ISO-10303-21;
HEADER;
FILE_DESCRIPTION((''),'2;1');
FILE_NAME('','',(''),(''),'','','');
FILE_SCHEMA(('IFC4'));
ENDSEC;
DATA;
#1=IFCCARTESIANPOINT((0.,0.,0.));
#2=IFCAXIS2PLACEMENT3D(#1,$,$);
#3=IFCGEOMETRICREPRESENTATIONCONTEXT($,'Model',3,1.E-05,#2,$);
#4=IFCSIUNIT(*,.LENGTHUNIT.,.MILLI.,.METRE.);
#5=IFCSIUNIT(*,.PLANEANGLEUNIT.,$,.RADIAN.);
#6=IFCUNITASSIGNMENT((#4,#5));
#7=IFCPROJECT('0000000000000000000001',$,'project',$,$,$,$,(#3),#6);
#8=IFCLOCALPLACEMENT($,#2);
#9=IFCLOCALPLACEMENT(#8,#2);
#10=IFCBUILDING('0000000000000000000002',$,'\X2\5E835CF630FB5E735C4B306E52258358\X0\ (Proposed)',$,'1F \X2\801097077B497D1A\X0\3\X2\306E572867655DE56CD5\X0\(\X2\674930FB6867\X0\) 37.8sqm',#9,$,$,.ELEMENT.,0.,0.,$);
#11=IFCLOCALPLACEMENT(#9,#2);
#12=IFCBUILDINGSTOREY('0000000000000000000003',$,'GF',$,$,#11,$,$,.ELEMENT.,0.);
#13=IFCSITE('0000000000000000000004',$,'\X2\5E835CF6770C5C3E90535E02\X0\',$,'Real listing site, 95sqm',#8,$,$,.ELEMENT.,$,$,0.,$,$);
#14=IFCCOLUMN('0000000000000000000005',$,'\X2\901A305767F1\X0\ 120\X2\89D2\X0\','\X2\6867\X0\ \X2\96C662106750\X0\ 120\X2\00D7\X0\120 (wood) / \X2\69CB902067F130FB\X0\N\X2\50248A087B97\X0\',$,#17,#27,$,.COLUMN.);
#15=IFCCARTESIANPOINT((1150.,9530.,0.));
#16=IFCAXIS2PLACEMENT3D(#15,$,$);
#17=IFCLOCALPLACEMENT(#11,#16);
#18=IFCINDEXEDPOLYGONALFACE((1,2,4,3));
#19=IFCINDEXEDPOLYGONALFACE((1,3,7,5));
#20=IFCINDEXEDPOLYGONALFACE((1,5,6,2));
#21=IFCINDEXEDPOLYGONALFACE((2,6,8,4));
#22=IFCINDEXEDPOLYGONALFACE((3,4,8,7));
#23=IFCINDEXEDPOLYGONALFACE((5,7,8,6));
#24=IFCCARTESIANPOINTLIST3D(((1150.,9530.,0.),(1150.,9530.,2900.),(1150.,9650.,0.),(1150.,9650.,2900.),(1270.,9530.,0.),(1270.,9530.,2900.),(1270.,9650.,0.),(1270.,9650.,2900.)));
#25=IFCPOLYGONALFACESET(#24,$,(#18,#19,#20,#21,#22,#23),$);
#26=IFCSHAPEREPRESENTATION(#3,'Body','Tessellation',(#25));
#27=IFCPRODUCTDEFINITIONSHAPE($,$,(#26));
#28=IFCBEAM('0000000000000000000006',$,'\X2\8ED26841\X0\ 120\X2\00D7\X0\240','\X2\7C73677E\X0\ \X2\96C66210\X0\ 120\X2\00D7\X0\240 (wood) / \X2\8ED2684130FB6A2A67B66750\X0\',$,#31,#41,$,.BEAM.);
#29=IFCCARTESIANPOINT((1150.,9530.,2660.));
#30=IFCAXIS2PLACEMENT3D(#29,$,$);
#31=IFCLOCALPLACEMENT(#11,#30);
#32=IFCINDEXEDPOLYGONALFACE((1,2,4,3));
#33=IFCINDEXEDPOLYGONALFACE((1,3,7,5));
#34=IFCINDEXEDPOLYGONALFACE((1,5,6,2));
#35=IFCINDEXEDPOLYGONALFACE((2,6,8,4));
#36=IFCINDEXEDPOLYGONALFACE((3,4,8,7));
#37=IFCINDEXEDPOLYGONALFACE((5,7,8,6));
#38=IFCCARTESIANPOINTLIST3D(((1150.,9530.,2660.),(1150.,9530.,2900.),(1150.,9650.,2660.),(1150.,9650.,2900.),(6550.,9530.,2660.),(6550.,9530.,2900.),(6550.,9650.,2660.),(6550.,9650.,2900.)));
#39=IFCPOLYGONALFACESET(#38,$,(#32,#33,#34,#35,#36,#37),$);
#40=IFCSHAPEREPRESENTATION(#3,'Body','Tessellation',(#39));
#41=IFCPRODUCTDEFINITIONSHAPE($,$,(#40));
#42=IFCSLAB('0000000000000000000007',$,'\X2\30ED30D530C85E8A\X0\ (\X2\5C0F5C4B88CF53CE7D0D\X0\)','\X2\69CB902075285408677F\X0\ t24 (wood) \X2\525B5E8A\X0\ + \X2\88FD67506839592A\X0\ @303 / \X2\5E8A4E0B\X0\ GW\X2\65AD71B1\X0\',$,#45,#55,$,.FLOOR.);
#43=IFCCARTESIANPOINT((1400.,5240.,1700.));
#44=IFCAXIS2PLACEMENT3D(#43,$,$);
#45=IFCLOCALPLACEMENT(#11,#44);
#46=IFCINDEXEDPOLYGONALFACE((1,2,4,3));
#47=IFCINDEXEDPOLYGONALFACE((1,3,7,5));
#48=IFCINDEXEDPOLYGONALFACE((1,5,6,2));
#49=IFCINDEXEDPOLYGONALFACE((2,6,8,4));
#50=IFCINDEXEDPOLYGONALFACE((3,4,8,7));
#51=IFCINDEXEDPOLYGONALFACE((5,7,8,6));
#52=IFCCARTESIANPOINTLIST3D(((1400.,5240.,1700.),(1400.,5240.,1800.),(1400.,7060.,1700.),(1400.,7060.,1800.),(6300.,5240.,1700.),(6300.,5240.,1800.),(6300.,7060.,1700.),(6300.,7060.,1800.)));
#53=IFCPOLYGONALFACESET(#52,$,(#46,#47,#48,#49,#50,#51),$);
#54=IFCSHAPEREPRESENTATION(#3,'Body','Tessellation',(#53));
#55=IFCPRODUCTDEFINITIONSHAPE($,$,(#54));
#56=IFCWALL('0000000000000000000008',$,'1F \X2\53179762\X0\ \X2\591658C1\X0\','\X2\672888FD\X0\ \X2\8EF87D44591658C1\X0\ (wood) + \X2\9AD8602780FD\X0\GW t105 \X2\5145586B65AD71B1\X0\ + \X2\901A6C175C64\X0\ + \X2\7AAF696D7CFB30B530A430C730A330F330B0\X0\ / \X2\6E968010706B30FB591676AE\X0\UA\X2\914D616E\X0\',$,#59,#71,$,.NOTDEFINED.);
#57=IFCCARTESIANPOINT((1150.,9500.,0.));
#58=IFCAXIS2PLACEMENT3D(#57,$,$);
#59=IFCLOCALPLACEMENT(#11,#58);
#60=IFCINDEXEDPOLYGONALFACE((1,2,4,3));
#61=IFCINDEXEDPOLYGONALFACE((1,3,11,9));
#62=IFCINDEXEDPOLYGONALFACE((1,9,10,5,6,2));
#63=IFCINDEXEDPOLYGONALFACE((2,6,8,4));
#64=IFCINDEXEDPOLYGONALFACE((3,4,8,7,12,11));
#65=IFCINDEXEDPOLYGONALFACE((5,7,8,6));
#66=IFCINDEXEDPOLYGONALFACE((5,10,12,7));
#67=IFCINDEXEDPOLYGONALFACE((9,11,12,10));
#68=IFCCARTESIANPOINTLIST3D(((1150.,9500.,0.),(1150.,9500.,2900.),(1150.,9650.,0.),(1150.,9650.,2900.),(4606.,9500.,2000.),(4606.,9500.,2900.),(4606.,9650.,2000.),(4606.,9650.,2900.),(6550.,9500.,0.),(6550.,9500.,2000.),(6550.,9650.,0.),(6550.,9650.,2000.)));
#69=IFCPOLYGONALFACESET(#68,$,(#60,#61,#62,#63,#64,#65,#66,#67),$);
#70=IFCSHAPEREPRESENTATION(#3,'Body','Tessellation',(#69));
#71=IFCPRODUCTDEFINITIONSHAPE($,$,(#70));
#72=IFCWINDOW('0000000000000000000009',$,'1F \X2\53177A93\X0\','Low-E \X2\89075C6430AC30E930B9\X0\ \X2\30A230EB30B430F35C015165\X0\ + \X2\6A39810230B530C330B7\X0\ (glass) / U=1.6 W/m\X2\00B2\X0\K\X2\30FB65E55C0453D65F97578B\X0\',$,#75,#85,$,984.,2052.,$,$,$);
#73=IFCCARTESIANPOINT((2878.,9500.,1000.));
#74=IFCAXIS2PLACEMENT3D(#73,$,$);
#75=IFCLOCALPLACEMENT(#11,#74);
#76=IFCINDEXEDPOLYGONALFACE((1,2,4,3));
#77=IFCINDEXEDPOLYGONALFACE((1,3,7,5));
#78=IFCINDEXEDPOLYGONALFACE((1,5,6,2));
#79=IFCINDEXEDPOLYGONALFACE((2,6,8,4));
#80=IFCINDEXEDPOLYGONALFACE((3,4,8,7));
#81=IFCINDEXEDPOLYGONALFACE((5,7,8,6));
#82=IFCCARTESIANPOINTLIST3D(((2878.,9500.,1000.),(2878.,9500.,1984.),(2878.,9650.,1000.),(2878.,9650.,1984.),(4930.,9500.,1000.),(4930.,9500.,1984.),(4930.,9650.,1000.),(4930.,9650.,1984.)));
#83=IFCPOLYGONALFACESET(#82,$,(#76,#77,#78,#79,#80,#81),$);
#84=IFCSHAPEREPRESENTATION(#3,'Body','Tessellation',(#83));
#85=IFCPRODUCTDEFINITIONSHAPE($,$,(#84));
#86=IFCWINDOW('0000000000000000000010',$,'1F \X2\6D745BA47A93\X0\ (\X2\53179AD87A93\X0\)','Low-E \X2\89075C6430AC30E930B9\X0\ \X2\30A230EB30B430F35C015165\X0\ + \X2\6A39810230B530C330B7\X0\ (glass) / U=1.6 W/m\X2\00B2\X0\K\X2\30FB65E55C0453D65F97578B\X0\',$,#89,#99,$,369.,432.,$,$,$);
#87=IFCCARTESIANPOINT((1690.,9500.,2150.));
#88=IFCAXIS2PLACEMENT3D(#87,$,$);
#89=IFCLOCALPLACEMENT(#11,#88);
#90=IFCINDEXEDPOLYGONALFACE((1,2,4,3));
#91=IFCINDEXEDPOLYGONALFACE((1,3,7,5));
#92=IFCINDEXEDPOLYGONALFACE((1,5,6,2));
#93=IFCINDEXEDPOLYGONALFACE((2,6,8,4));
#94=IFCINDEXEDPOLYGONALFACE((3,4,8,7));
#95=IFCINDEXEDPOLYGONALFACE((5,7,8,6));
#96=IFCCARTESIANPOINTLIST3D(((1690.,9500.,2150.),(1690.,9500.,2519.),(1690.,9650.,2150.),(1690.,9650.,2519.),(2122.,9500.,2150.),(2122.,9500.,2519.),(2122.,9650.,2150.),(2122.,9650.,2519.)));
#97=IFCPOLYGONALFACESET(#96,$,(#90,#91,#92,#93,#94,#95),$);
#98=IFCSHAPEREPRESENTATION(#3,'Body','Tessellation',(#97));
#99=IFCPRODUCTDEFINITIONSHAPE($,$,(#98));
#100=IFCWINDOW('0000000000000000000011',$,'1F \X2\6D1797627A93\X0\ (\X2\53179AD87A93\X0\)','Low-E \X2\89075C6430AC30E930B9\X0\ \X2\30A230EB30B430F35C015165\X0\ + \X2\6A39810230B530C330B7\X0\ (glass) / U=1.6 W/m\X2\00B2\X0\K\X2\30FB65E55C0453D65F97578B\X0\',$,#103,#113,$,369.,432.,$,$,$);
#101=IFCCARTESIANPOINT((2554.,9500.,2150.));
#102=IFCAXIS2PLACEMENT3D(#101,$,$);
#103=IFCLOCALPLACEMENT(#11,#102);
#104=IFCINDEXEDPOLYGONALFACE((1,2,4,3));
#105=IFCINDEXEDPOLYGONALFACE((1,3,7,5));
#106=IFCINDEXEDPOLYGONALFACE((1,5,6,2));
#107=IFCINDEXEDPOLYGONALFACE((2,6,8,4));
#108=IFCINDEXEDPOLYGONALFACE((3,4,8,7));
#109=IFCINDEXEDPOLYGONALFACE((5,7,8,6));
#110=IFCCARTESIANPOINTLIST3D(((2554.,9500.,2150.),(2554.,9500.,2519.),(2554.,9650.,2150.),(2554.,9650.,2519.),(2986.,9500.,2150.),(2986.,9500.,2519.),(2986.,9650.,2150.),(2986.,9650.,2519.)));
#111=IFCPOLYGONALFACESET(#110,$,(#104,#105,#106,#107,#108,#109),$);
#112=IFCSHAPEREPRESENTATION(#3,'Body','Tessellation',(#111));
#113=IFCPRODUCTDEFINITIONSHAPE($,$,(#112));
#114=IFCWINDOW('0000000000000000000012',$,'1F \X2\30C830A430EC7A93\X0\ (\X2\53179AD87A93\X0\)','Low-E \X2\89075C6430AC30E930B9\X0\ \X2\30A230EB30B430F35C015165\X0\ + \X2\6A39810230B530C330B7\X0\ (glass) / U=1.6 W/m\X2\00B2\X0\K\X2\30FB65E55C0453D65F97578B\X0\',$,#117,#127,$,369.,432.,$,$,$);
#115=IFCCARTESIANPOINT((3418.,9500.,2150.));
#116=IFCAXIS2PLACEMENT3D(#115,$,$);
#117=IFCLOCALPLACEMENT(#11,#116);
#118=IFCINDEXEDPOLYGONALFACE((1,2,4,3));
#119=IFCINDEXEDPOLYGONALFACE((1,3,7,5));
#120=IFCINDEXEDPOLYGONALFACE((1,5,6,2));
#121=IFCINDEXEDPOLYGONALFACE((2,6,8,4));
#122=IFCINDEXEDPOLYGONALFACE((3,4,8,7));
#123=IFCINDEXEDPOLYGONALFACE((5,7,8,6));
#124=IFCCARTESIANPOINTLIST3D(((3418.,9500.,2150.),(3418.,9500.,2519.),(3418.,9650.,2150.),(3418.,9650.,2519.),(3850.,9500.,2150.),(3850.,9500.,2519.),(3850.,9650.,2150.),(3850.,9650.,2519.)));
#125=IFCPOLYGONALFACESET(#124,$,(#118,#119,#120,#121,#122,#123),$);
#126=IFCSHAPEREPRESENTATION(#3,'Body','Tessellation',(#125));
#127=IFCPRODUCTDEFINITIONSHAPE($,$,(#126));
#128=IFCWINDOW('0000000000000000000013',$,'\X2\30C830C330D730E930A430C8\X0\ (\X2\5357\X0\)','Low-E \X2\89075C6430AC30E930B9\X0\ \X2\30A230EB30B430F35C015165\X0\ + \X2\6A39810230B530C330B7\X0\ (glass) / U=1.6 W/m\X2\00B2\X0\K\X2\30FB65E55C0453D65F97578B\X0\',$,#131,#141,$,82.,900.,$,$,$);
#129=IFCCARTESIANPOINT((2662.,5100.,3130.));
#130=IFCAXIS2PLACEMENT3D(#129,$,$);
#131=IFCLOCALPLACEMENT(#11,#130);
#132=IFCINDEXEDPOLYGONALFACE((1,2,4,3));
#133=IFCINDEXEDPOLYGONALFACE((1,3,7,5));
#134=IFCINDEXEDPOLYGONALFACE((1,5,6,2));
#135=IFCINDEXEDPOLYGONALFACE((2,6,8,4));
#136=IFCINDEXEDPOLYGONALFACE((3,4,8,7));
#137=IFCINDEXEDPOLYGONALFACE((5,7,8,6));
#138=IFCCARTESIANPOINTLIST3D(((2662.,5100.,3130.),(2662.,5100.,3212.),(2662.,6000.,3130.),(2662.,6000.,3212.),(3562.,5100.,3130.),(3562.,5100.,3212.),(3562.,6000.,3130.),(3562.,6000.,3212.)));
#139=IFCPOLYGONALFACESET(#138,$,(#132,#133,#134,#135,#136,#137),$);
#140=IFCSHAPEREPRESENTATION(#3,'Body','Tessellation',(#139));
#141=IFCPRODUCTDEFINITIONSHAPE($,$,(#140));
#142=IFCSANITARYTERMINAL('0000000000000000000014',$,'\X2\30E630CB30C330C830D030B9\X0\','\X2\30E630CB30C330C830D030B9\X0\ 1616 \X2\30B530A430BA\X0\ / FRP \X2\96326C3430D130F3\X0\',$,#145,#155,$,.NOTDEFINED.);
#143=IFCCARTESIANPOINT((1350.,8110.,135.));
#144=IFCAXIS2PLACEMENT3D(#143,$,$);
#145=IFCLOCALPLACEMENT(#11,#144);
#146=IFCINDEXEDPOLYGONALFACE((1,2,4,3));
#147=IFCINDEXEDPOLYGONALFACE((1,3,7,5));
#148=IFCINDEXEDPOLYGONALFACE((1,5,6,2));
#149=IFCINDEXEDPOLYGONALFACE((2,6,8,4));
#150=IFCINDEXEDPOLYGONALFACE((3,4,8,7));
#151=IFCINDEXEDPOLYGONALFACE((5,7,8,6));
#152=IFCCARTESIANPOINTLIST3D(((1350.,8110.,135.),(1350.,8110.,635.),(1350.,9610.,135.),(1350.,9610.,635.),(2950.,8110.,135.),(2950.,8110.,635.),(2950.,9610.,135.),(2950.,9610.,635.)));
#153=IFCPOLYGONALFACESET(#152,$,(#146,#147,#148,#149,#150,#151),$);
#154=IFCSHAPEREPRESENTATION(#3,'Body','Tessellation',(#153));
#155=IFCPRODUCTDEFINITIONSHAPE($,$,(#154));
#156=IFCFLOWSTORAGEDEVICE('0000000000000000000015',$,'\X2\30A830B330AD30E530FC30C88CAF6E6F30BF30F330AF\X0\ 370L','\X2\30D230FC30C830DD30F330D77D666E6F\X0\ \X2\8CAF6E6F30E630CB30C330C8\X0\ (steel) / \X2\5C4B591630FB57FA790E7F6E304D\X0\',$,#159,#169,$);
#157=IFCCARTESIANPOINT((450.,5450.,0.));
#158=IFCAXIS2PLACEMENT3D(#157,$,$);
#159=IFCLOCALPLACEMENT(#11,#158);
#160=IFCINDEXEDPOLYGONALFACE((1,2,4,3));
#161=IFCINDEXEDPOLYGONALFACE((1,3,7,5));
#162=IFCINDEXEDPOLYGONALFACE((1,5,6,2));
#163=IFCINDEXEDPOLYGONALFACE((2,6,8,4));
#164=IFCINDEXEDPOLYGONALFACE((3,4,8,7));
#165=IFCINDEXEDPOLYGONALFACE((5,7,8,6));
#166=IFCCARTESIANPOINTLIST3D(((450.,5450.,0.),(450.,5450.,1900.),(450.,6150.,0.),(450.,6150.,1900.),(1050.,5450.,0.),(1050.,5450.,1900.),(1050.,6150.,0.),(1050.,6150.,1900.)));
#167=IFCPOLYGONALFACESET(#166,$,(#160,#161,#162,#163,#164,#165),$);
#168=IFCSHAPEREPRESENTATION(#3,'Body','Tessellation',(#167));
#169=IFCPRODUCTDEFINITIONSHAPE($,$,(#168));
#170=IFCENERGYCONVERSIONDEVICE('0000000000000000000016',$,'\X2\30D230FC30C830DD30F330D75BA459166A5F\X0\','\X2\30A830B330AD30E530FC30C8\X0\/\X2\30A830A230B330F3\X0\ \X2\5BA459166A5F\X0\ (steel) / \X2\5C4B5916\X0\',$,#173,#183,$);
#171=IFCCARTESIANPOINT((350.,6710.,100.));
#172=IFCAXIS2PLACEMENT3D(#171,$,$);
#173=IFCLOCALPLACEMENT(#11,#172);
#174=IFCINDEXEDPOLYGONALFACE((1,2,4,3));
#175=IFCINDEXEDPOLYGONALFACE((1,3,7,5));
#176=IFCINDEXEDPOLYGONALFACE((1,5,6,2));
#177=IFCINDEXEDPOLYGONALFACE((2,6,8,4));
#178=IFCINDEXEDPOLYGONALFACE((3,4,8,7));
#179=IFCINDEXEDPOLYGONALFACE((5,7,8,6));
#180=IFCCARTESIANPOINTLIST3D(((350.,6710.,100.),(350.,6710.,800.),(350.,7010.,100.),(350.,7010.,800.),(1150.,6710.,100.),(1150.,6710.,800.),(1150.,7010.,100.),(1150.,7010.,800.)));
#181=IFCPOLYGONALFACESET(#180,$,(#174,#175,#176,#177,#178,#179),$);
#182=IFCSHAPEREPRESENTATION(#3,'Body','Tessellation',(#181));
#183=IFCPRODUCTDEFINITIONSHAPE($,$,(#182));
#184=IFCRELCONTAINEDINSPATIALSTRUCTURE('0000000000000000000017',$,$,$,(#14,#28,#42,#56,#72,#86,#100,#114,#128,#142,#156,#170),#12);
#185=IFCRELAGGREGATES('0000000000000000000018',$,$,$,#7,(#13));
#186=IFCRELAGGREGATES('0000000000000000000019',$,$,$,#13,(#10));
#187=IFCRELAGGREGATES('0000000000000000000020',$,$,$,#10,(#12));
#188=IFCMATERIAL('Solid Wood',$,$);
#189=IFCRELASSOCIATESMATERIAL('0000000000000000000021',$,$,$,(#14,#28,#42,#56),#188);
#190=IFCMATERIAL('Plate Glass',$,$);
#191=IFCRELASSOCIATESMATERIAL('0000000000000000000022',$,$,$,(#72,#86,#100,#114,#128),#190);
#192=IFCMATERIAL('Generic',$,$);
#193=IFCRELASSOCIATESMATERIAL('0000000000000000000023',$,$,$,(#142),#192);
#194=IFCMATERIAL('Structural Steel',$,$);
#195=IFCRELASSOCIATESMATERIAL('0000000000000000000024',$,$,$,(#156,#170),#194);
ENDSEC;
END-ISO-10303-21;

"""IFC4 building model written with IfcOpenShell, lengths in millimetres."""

from ifc_helpers import new_model, si_unit, frame, frame_2d, origin, place, context, project, spatial, rectangle, extrude, material, element, fill, save


model = new_model("IFC4")

# Units and contexts
model_context = context("Model", 3, precision=1e-05, world=origin())
ifc_project = project(units=[si_unit("LENGTHUNIT", "METRE", prefix="MILLI"), si_unit("PLANEANGLEUNIT", "RADIAN")], contexts=[model_context])

# Site, building, storey
site_placement = place(None, origin())
site = spatial("IfcSite", under=ifc_project, at=site_placement, Name="広島県尾道市", ObjectType="Real listing site, 95sqm", CompositionType="ELEMENT", RefElevation=0.0)
building_placement = place(site_placement, origin())
building = spatial("IfcBuilding", under=site, at=building_placement, Name="広島・平屋の別荘 (Proposed)", ObjectType="1F 耐震等級3の在来工法(杉・桧) 37.8sqm", CompositionType="ELEMENT", ElevationOfRefHeight=0.0, ElevationOfTerrain=0.0)
storey_placement = place(building_placement, origin())
storey = spatial("IfcBuildingStorey", under=building, at=storey_placement, Name="GF", CompositionType="ELEMENT", Elevation=0.0)

# Column
ifc_material_1 = material(Name="Solid Wood")
column_1_placement = place(storey_placement, frame((1150.0, 9530.0, 0.0)))
element("IfcColumn", 1, at=column_1_placement, inside=storey, material=ifc_material_1, Name="通し柱 120角", Description="桧 集成材 120×120 (wood) / 構造柱・N値計算", PredefinedType="COLUMN", context=model_context, shape_type="SweptSolid", body=[
    extrude(rectangle(XDim=120.0, YDim=120.0, at=frame_2d((60.0, 60.0))), frame((1150.0, 9530.0, 0.0)), (0.0, 0.0, 1.0), 2900.0),
])

# Beam
beam_1_placement = place(storey_placement, frame((1150.0, 9530.0, 2660.0)))
element("IfcBeam", 2, at=beam_1_placement, inside=storey, material=ifc_material_1, Name="軒桁 120×240", Description="米松 集成 120×240 (wood) / 軒桁・横架材", PredefinedType="BEAM", context=model_context, shape_type="SweptSolid", body=[
    extrude(rectangle(XDim=5400.0, YDim=120.0, at=frame_2d((2700.0, 60.0))), frame((1150.0, 9530.0, 2660.0)), (0.0, 0.0, 1.0), 240.0),
])

# Slab
slab_placement = place(storey_placement, frame((1400.0, 5240.0, 1700.0)))
element("IfcSlab", 3, at=slab_placement, inside=storey, material=ifc_material_1, Name="ロフト床 (小屋裏収納)", Description="構造用合板 t24 (wood) 剛床 + 製材根太 @303 / 床下 GW断熱", PredefinedType="FLOOR", context=model_context, shape_type="SweptSolid", body=[
    extrude(rectangle(XDim=4900.0, YDim=1820.0, at=frame_2d((2450.0, 910.0))), frame((1400.0, 5240.0, 1700.0)), (0.0, 0.0, 1.0), 100.0),
])

# Wall, openings, windows
wall_1_placement = place(storey_placement, frame((1150.0, 9500.0, 0.0)))
wall_1 = element("IfcWall", 4, at=wall_1_placement, inside=storey, material=ifc_material_1, Name="1F 北面 外壁", Description="木製 軸組外壁 (wood) + 高性能GW t105 充填断熱 + 通気層 + 窯業系サイディング / 準耐火・外皮UA配慮", PredefinedType="NOTDEFINED", context=model_context, shape_type="SweptSolid", body=[
    extrude(rectangle(XDim=5400.0, YDim=150.0, at=frame_2d((2700.0, 75.0))), frame((1150.0, 9500.0, 0.0)), (0.0, 0.0, 1.0), 2900.0),
])
opening_1_placement = place(storey_placement, frame((2878.0, 9500.0, 1000.0)))
opening_1 = element("IfcOpeningElement", 5, at=opening_1_placement, cuts=wall_1, PredefinedType="NOTDEFINED", context=model_context, shape_type="SweptSolid", body=[
    extrude(rectangle(XDim=2052.0, YDim=150.0, at=frame_2d((1026.0, 75.0))), frame((2878.0, 9500.0, 1000.0)), (0.0, 0.0, 1.0), 984.0),
])
opening_2_placement = place(storey_placement, frame((1690.0, 9500.0, 2150.0)))
opening_2 = element("IfcOpeningElement", 6, at=opening_2_placement, cuts=wall_1, PredefinedType="NOTDEFINED", context=model_context, shape_type="SweptSolid", body=[
    extrude(rectangle(XDim=432.0, YDim=150.0, at=frame_2d((216.0, 75.0))), frame((1690.0, 9500.0, 2150.0)), (0.0, 0.0, 1.0), 369.0),
])
opening_3_placement = place(storey_placement, frame((2554.0, 9500.0, 2150.0)))
opening_3 = element("IfcOpeningElement", 7, at=opening_3_placement, cuts=wall_1, PredefinedType="NOTDEFINED", context=model_context, shape_type="SweptSolid", body=[
    extrude(rectangle(XDim=432.0, YDim=150.0, at=frame_2d((216.0, 75.0))), frame((2554.0, 9500.0, 2150.0)), (0.0, 0.0, 1.0), 369.0),
])
opening_4_placement = place(storey_placement, frame((3418.0, 9500.0, 2150.0)))
opening_4 = element("IfcOpeningElement", 8, at=opening_4_placement, cuts=wall_1, PredefinedType="NOTDEFINED", context=model_context, shape_type="SweptSolid", body=[
    extrude(rectangle(XDim=432.0, YDim=150.0, at=frame_2d((216.0, 75.0))), frame((3418.0, 9500.0, 2150.0)), (0.0, 0.0, 1.0), 369.0),
])
ifc_material_2 = material(Name="Plate Glass")
window_1_placement = place(storey_placement, frame((2878.0, 9500.0, 1000.0)))
window_1 = element("IfcWindow", 9, at=window_1_placement, inside=storey, material=ifc_material_2, Name="1F 北窓", Description="Low-E 複層ガラス アルゴン封入 + 樹脂サッシ (glass) / U=1.6 W/m²K・日射取得型", OverallHeight=984.0, OverallWidth=2052.0, context=model_context, shape_type="SweptSolid", body=[
    extrude(rectangle(XDim=2052.0, YDim=150.0, at=frame_2d((1026.0, 75.0))), frame((2878.0, 9500.0, 1000.0)), (0.0, 0.0, 1.0), 984.0),
])
fill(opening_1, window_1)
window_2_placement = place(storey_placement, frame((1690.0, 9500.0, 2150.0)))
window_2 = element("IfcWindow", 10, at=window_2_placement, inside=storey, material=ifc_material_2, Name="1F 浴室窓 (北高窓)", Description="Low-E 複層ガラス アルゴン封入 + 樹脂サッシ (glass) / U=1.6 W/m²K・日射取得型", OverallHeight=369.0, OverallWidth=432.0, context=model_context, shape_type="SweptSolid", body=[
    extrude(rectangle(XDim=432.0, YDim=150.0, at=frame_2d((216.0, 75.0))), frame((1690.0, 9500.0, 2150.0)), (0.0, 0.0, 1.0), 369.0),
])
fill(opening_2, window_2)
window_3_placement = place(storey_placement, frame((2554.0, 9500.0, 2150.0)))
window_3 = element("IfcWindow", 11, at=window_3_placement, inside=storey, material=ifc_material_2, Name="1F 洗面窓 (北高窓)", Description="Low-E 複層ガラス アルゴン封入 + 樹脂サッシ (glass) / U=1.6 W/m²K・日射取得型", OverallHeight=369.0, OverallWidth=432.0, context=model_context, shape_type="SweptSolid", body=[
    extrude(rectangle(XDim=432.0, YDim=150.0, at=frame_2d((216.0, 75.0))), frame((2554.0, 9500.0, 2150.0)), (0.0, 0.0, 1.0), 369.0),
])
fill(opening_3, window_3)
window_4_placement = place(storey_placement, frame((3418.0, 9500.0, 2150.0)))
window_4 = element("IfcWindow", 12, at=window_4_placement, inside=storey, material=ifc_material_2, Name="1F トイレ窓 (北高窓)", Description="Low-E 複層ガラス アルゴン封入 + 樹脂サッシ (glass) / U=1.6 W/m²K・日射取得型", OverallHeight=369.0, OverallWidth=432.0, context=model_context, shape_type="SweptSolid", body=[
    extrude(rectangle(XDim=432.0, YDim=150.0, at=frame_2d((216.0, 75.0))), frame((3418.0, 9500.0, 2150.0)), (0.0, 0.0, 1.0), 369.0),
])
fill(opening_4, window_4)

# Window
window_5_placement = place(storey_placement, frame((2662.0, 5100.0, 3130.0)))
element("IfcWindow", 13, at=window_5_placement, inside=storey, material=ifc_material_2, Name="トップライト (南)", Description="Low-E 複層ガラス アルゴン封入 + 樹脂サッシ (glass) / U=1.6 W/m²K・日射取得型", OverallHeight=82.0, OverallWidth=900.0, context=model_context, shape_type="SweptSolid", body=[
    extrude(rectangle(XDim=900.0, YDim=900.0, at=frame_2d((450.0, 450.0))), frame((2662.0, 5100.0, 3130.0)), (0.0, 0.0, 1.0), 82.0),
])

# Sanitary terminal
ifc_material_3 = material(Name="Generic")
sanitary_terminal_placement = place(storey_placement, frame((1350.0, 8110.0, 135.0)))
element("IfcSanitaryTerminal", 14, at=sanitary_terminal_placement, inside=storey, material=ifc_material_3, Name="ユニットバス", Description="ユニットバス 1616 サイズ / FRP 防水パン", PredefinedType="NOTDEFINED", context=model_context, shape_type="SweptSolid", body=[
    extrude(rectangle(XDim=1600.0, YDim=1500.0, at=frame_2d((800.0, 750.0))), frame((1350.0, 8110.0, 135.0)), (0.0, 0.0, 1.0), 500.0),
])

# Flow storage device
ifc_material_4 = material(Name="Structural Steel")
flow_storage_device_placement = place(storey_placement, frame((450.0, 5450.0, 0.0)))
element("IfcFlowStorageDevice", 15, at=flow_storage_device_placement, inside=storey, material=ifc_material_4, Name="エコキュート貯湯タンク 370L", Description="ヒートポンプ給湯 貯湯ユニット (steel) / 屋外・基礎置き", context=model_context, shape_type="SweptSolid", body=[
    extrude(rectangle(XDim=600.0, YDim=700.0, at=frame_2d((300.0, 350.0))), frame((450.0, 5450.0, 0.0)), (0.0, 0.0, 1.0), 1900.0),
])

# Energy conversion device
energy_conversion_device_placement = place(storey_placement, frame((350.0, 6710.0, 100.0)))
element("IfcEnergyConversionDevice", 16, at=energy_conversion_device_placement, inside=storey, material=ifc_material_4, Name="ヒートポンプ室外機", Description="エコキュート/エアコン 室外機 (steel) / 屋外", context=model_context, shape_type="SweptSolid", body=[
    extrude(rectangle(XDim=800.0, YDim=300.0, at=frame_2d((400.0, 150.0))), frame((350.0, 6710.0, 100.0)), (0.0, 0.0, 1.0), 700.0),
])

save(model, "model.ifc")
